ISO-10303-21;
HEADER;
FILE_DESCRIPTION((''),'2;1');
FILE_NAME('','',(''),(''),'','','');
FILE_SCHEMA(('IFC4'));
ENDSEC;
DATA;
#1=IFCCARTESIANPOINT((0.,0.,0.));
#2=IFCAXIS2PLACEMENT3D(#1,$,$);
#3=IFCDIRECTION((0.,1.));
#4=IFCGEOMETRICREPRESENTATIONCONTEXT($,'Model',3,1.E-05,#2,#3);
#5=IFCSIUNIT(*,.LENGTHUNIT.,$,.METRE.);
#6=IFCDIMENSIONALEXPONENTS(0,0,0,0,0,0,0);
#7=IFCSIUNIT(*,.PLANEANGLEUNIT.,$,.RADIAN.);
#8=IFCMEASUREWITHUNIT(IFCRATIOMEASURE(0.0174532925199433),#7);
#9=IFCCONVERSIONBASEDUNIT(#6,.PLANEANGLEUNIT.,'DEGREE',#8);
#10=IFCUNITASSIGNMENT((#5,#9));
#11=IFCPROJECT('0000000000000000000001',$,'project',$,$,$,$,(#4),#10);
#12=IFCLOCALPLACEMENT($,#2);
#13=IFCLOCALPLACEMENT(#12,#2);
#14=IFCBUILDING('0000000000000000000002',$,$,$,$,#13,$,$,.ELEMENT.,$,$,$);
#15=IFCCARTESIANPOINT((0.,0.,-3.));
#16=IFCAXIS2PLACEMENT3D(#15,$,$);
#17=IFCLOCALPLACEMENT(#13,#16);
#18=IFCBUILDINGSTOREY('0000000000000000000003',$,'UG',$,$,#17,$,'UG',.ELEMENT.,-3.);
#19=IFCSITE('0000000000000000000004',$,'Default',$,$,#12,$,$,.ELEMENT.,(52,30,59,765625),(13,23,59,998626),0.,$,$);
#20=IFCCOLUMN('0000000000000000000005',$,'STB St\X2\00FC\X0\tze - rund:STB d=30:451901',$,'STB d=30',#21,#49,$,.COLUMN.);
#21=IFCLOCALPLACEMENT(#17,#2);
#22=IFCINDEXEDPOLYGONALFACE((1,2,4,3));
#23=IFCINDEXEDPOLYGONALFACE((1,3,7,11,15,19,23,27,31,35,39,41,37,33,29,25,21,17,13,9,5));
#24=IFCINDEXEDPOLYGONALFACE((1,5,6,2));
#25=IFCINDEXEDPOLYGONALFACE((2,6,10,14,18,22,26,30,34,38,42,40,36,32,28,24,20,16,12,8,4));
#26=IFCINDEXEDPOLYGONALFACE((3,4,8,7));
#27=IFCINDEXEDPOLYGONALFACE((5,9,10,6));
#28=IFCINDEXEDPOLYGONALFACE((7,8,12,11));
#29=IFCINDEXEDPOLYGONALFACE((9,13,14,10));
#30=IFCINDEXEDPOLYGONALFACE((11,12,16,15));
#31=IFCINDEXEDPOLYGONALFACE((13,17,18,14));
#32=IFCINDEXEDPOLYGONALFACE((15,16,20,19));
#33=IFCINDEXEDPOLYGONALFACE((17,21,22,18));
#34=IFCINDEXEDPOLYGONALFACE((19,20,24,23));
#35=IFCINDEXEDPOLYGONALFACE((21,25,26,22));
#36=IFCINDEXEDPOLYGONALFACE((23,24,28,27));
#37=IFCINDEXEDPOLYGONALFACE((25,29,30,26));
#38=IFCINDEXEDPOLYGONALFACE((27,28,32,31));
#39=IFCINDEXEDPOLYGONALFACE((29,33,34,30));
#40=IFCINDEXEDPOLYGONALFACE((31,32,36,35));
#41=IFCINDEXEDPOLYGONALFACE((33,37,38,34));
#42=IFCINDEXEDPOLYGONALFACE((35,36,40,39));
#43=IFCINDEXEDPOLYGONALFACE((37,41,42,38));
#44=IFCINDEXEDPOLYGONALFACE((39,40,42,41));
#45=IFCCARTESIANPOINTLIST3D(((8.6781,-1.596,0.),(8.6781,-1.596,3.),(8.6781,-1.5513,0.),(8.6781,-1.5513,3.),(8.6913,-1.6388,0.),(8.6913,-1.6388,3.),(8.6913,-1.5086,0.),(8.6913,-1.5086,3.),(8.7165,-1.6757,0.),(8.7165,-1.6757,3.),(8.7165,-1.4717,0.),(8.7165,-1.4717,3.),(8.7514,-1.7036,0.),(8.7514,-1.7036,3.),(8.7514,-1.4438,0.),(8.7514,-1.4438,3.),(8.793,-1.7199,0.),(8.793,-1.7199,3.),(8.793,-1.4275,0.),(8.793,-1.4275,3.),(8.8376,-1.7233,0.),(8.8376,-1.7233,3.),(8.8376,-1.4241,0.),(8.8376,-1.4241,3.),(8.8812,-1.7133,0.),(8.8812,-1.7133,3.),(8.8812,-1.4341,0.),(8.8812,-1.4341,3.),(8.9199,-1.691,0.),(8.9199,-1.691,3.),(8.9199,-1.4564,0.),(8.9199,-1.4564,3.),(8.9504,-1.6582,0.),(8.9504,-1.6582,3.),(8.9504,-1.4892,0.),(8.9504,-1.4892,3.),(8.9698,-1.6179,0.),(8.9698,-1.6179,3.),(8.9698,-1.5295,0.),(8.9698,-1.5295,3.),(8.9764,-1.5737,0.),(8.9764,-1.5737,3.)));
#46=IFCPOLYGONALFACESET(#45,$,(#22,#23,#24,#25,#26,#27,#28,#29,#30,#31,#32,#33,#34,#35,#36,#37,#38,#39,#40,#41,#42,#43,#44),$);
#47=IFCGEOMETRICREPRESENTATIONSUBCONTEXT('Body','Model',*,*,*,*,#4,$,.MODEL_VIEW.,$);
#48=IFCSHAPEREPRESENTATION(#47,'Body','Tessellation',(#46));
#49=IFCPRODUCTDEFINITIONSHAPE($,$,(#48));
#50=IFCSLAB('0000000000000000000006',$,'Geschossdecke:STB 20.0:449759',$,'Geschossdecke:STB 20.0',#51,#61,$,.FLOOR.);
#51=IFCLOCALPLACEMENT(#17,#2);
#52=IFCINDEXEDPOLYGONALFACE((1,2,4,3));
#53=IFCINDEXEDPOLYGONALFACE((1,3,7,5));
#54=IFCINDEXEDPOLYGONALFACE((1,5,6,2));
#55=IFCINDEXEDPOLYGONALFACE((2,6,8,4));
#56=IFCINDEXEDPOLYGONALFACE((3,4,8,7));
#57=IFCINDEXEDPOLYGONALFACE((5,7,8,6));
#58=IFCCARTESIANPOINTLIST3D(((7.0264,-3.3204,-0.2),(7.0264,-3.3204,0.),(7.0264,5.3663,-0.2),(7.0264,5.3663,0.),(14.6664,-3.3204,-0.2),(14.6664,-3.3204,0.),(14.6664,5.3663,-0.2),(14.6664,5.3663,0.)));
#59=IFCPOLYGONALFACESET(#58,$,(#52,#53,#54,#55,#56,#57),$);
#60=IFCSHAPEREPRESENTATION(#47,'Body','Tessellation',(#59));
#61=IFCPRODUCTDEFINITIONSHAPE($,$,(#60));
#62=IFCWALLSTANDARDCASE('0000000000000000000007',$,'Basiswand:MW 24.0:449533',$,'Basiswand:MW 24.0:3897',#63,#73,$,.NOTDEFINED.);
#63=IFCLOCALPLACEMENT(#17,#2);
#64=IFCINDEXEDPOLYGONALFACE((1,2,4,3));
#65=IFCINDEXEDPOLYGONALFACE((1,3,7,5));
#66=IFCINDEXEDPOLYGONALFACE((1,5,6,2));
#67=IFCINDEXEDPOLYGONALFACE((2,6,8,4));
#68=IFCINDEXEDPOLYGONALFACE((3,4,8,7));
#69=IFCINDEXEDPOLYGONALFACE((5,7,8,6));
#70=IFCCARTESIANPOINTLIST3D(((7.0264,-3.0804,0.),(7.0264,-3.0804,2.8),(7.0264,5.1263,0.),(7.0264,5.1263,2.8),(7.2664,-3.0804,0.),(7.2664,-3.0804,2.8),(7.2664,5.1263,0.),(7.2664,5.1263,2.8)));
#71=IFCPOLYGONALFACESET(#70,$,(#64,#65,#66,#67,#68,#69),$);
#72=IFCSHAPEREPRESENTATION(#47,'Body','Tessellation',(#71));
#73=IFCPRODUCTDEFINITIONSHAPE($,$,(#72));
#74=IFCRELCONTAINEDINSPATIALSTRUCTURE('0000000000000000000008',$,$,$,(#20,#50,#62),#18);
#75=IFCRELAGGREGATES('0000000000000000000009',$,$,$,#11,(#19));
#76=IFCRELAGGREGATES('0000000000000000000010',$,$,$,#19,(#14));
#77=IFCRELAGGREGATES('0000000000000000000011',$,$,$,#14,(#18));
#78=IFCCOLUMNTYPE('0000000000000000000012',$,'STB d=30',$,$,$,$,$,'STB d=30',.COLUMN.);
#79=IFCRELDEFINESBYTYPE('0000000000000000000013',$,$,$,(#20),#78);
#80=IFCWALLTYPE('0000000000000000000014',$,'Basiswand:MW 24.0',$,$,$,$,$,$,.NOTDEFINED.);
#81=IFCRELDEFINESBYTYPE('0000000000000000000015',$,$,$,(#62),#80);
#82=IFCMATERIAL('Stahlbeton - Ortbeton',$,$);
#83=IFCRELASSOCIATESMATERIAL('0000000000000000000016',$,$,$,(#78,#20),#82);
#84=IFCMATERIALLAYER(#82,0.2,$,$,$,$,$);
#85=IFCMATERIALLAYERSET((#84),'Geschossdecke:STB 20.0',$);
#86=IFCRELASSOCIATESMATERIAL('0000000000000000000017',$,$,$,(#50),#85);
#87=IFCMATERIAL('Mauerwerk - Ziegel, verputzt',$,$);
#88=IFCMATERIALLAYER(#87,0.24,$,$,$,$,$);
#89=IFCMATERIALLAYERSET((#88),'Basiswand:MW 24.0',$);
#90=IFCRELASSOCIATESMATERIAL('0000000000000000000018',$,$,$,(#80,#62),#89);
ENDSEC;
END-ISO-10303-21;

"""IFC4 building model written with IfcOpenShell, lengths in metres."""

from ifc_helpers import new_model, entity, si_unit, converted_unit, direction, frame, frame_2d, origin, place, context, subcontext, project, spatial, polyline, rectangle, circle, extrude, clip, bounded_halfspace, source, transform, mapped, material, layer, layer_set, layer_usage, type_object, type_shapes, element, save


model = new_model("IFC4")

# Units and contexts
model_context = context("Model", 3, precision=1e-05, world=origin(), true_north=direction((0.0, 1.0)))
body_context = subcontext(model_context, "Body", "Model", "MODEL_VIEW")
ifc_project = project(units=[si_unit("LENGTHUNIT", "METRE"), converted_unit("PLANEANGLEUNIT", "DEGREE", entity("IfcRatioMeasure", 0.0174532925199433), si_unit("PLANEANGLEUNIT", "RADIAN"), dimensions=[0, 0, 0, 0, 0, 0, 0])], contexts=[model_context])

# Site, building, storey
site_placement = place(None, origin())
site = spatial("IfcSite", under=ifc_project, at=site_placement, Name="Default", CompositionType="ELEMENT", RefLatitude=(52, 30, 59, 765625), RefLongitude=(13, 23, 59, 998626), RefElevation=0.0)
building_placement = place(site_placement, origin())
building = spatial("IfcBuilding", under=site, at=building_placement, CompositionType="ELEMENT")
storey_placement = place(building_placement, frame((0.0, 0.0, -3.0)))
storey = spatial("IfcBuildingStorey", under=building, at=storey_placement, Name="UG", LongName="UG", CompositionType="ELEMENT", Elevation=-3.0)

# Column
ifc_material_1 = material(Name="Stahlbeton - Ortbeton")
column_type = type_object("IfcColumnType", Name="STB d=30", ElementType="STB d=30", PredefinedType="COLUMN", material=ifc_material_1)
shared_shape = source(origin(), body_context, "Body", "SweptSolid", [
    extrude(circle(Radius=0.15, at=frame_2d((0.0, 0.0), x_axis=(1.0, 0.0))), frame((0.0, 0.0, -3.0)), (0.0, 0.0, 1.0), 3.0),
])
type_shapes(column_type, [shared_shape])
column_placement = place(storey_placement, frame((8.8264, -1.5737, 3.0)))
element("IfcColumn", 1, at=column_placement, inside=storey, type_object=column_type, material=ifc_material_1, Name="STB Stütze - rund:STB d=30:451901", ObjectType="STB d=30", PredefinedType="COLUMN", context=body_context, shape_type="MappedRepresentation", body=[
    mapped(shared_shape, transform((0.0, 0.0, 0.0), scale=1.0)),
])

# Slab
ifc_layer_1 = layer(ifc_material_1, 0.2)
ifc_layer_set_1 = layer_set([ifc_layer_1], Name="Geschossdecke:STB 20.0")
ifc_layer_usage_1 = layer_usage(ifc_layer_set_1, "AXIS3", "POSITIVE", 0.0)
slab_placement = place(storey_placement, origin())
element("IfcSlab", 2, at=slab_placement, inside=storey, material=ifc_layer_usage_1, Name="Geschossdecke:STB 20.0:449759", ObjectType="Geschossdecke:STB 20.0", PredefinedType="FLOOR", context=body_context, shape_type="SweptSolid", body=[
    extrude(rectangle(XDim=8.6867, YDim=7.64, at=frame_2d((0.0, 0.0), x_axis=(1.0, 0.0))), frame((10.8464, 1.023, 0.0), z_axis=(0.0, 0.0, -1.0), x_axis=(0.0, 1.0, 0.0)), (0.0, 0.0, 1.0), 0.2),
])

# Wall
ifc_material_2 = material(Name="Mauerwerk - Ziegel, verputzt")
ifc_layer_2 = layer(ifc_material_2, 0.24)
ifc_layer_set_2 = layer_set([ifc_layer_2], Name="Basiswand:MW 24.0")
ifc_layer_usage_2 = layer_usage(ifc_layer_set_2, "AXIS2", "NEGATIVE", 0.12)
wall_type = type_object("IfcWallType", Name="Basiswand:MW 24.0", PredefinedType="NOTDEFINED", material=ifc_layer_set_2)
wall_placement = place(storey_placement, frame((7.1464, 5.1263, 0.0), z_axis=(0.0, 0.0, 1.0), x_axis=(0.0, -1.0, 0.0)))
element("IfcWallStandardCase", 3, at=wall_placement, inside=storey, type_object=wall_type, material=ifc_layer_usage_2, Name="Basiswand:MW 24.0:449533", ObjectType="Basiswand:MW 24.0:3897", PredefinedType="NOTDEFINED", context=body_context, shape_type="Clipping", body=[
    clip(extrude(rectangle(XDim=8.2067, YDim=0.24, at=frame_2d((4.1034, 0.0), x_axis=(-1.0, 0.0))), origin(), (0.0, 0.0, 1.0), 2.8), bounded_halfspace(frame((0.0, -0.12, 2.8), z_axis=(0.0, 0.0, -1.0), x_axis=(1.0, 0.0, 0.0)), True, frame((0.0, -0.12, 2.8)), polyline([(0.0, 0.0), (8.2067, 0.0), (8.2067, 0.24), (0.0, 0.24), (0.0, 0.0)]))),
])

save(model, "model.ifc")
